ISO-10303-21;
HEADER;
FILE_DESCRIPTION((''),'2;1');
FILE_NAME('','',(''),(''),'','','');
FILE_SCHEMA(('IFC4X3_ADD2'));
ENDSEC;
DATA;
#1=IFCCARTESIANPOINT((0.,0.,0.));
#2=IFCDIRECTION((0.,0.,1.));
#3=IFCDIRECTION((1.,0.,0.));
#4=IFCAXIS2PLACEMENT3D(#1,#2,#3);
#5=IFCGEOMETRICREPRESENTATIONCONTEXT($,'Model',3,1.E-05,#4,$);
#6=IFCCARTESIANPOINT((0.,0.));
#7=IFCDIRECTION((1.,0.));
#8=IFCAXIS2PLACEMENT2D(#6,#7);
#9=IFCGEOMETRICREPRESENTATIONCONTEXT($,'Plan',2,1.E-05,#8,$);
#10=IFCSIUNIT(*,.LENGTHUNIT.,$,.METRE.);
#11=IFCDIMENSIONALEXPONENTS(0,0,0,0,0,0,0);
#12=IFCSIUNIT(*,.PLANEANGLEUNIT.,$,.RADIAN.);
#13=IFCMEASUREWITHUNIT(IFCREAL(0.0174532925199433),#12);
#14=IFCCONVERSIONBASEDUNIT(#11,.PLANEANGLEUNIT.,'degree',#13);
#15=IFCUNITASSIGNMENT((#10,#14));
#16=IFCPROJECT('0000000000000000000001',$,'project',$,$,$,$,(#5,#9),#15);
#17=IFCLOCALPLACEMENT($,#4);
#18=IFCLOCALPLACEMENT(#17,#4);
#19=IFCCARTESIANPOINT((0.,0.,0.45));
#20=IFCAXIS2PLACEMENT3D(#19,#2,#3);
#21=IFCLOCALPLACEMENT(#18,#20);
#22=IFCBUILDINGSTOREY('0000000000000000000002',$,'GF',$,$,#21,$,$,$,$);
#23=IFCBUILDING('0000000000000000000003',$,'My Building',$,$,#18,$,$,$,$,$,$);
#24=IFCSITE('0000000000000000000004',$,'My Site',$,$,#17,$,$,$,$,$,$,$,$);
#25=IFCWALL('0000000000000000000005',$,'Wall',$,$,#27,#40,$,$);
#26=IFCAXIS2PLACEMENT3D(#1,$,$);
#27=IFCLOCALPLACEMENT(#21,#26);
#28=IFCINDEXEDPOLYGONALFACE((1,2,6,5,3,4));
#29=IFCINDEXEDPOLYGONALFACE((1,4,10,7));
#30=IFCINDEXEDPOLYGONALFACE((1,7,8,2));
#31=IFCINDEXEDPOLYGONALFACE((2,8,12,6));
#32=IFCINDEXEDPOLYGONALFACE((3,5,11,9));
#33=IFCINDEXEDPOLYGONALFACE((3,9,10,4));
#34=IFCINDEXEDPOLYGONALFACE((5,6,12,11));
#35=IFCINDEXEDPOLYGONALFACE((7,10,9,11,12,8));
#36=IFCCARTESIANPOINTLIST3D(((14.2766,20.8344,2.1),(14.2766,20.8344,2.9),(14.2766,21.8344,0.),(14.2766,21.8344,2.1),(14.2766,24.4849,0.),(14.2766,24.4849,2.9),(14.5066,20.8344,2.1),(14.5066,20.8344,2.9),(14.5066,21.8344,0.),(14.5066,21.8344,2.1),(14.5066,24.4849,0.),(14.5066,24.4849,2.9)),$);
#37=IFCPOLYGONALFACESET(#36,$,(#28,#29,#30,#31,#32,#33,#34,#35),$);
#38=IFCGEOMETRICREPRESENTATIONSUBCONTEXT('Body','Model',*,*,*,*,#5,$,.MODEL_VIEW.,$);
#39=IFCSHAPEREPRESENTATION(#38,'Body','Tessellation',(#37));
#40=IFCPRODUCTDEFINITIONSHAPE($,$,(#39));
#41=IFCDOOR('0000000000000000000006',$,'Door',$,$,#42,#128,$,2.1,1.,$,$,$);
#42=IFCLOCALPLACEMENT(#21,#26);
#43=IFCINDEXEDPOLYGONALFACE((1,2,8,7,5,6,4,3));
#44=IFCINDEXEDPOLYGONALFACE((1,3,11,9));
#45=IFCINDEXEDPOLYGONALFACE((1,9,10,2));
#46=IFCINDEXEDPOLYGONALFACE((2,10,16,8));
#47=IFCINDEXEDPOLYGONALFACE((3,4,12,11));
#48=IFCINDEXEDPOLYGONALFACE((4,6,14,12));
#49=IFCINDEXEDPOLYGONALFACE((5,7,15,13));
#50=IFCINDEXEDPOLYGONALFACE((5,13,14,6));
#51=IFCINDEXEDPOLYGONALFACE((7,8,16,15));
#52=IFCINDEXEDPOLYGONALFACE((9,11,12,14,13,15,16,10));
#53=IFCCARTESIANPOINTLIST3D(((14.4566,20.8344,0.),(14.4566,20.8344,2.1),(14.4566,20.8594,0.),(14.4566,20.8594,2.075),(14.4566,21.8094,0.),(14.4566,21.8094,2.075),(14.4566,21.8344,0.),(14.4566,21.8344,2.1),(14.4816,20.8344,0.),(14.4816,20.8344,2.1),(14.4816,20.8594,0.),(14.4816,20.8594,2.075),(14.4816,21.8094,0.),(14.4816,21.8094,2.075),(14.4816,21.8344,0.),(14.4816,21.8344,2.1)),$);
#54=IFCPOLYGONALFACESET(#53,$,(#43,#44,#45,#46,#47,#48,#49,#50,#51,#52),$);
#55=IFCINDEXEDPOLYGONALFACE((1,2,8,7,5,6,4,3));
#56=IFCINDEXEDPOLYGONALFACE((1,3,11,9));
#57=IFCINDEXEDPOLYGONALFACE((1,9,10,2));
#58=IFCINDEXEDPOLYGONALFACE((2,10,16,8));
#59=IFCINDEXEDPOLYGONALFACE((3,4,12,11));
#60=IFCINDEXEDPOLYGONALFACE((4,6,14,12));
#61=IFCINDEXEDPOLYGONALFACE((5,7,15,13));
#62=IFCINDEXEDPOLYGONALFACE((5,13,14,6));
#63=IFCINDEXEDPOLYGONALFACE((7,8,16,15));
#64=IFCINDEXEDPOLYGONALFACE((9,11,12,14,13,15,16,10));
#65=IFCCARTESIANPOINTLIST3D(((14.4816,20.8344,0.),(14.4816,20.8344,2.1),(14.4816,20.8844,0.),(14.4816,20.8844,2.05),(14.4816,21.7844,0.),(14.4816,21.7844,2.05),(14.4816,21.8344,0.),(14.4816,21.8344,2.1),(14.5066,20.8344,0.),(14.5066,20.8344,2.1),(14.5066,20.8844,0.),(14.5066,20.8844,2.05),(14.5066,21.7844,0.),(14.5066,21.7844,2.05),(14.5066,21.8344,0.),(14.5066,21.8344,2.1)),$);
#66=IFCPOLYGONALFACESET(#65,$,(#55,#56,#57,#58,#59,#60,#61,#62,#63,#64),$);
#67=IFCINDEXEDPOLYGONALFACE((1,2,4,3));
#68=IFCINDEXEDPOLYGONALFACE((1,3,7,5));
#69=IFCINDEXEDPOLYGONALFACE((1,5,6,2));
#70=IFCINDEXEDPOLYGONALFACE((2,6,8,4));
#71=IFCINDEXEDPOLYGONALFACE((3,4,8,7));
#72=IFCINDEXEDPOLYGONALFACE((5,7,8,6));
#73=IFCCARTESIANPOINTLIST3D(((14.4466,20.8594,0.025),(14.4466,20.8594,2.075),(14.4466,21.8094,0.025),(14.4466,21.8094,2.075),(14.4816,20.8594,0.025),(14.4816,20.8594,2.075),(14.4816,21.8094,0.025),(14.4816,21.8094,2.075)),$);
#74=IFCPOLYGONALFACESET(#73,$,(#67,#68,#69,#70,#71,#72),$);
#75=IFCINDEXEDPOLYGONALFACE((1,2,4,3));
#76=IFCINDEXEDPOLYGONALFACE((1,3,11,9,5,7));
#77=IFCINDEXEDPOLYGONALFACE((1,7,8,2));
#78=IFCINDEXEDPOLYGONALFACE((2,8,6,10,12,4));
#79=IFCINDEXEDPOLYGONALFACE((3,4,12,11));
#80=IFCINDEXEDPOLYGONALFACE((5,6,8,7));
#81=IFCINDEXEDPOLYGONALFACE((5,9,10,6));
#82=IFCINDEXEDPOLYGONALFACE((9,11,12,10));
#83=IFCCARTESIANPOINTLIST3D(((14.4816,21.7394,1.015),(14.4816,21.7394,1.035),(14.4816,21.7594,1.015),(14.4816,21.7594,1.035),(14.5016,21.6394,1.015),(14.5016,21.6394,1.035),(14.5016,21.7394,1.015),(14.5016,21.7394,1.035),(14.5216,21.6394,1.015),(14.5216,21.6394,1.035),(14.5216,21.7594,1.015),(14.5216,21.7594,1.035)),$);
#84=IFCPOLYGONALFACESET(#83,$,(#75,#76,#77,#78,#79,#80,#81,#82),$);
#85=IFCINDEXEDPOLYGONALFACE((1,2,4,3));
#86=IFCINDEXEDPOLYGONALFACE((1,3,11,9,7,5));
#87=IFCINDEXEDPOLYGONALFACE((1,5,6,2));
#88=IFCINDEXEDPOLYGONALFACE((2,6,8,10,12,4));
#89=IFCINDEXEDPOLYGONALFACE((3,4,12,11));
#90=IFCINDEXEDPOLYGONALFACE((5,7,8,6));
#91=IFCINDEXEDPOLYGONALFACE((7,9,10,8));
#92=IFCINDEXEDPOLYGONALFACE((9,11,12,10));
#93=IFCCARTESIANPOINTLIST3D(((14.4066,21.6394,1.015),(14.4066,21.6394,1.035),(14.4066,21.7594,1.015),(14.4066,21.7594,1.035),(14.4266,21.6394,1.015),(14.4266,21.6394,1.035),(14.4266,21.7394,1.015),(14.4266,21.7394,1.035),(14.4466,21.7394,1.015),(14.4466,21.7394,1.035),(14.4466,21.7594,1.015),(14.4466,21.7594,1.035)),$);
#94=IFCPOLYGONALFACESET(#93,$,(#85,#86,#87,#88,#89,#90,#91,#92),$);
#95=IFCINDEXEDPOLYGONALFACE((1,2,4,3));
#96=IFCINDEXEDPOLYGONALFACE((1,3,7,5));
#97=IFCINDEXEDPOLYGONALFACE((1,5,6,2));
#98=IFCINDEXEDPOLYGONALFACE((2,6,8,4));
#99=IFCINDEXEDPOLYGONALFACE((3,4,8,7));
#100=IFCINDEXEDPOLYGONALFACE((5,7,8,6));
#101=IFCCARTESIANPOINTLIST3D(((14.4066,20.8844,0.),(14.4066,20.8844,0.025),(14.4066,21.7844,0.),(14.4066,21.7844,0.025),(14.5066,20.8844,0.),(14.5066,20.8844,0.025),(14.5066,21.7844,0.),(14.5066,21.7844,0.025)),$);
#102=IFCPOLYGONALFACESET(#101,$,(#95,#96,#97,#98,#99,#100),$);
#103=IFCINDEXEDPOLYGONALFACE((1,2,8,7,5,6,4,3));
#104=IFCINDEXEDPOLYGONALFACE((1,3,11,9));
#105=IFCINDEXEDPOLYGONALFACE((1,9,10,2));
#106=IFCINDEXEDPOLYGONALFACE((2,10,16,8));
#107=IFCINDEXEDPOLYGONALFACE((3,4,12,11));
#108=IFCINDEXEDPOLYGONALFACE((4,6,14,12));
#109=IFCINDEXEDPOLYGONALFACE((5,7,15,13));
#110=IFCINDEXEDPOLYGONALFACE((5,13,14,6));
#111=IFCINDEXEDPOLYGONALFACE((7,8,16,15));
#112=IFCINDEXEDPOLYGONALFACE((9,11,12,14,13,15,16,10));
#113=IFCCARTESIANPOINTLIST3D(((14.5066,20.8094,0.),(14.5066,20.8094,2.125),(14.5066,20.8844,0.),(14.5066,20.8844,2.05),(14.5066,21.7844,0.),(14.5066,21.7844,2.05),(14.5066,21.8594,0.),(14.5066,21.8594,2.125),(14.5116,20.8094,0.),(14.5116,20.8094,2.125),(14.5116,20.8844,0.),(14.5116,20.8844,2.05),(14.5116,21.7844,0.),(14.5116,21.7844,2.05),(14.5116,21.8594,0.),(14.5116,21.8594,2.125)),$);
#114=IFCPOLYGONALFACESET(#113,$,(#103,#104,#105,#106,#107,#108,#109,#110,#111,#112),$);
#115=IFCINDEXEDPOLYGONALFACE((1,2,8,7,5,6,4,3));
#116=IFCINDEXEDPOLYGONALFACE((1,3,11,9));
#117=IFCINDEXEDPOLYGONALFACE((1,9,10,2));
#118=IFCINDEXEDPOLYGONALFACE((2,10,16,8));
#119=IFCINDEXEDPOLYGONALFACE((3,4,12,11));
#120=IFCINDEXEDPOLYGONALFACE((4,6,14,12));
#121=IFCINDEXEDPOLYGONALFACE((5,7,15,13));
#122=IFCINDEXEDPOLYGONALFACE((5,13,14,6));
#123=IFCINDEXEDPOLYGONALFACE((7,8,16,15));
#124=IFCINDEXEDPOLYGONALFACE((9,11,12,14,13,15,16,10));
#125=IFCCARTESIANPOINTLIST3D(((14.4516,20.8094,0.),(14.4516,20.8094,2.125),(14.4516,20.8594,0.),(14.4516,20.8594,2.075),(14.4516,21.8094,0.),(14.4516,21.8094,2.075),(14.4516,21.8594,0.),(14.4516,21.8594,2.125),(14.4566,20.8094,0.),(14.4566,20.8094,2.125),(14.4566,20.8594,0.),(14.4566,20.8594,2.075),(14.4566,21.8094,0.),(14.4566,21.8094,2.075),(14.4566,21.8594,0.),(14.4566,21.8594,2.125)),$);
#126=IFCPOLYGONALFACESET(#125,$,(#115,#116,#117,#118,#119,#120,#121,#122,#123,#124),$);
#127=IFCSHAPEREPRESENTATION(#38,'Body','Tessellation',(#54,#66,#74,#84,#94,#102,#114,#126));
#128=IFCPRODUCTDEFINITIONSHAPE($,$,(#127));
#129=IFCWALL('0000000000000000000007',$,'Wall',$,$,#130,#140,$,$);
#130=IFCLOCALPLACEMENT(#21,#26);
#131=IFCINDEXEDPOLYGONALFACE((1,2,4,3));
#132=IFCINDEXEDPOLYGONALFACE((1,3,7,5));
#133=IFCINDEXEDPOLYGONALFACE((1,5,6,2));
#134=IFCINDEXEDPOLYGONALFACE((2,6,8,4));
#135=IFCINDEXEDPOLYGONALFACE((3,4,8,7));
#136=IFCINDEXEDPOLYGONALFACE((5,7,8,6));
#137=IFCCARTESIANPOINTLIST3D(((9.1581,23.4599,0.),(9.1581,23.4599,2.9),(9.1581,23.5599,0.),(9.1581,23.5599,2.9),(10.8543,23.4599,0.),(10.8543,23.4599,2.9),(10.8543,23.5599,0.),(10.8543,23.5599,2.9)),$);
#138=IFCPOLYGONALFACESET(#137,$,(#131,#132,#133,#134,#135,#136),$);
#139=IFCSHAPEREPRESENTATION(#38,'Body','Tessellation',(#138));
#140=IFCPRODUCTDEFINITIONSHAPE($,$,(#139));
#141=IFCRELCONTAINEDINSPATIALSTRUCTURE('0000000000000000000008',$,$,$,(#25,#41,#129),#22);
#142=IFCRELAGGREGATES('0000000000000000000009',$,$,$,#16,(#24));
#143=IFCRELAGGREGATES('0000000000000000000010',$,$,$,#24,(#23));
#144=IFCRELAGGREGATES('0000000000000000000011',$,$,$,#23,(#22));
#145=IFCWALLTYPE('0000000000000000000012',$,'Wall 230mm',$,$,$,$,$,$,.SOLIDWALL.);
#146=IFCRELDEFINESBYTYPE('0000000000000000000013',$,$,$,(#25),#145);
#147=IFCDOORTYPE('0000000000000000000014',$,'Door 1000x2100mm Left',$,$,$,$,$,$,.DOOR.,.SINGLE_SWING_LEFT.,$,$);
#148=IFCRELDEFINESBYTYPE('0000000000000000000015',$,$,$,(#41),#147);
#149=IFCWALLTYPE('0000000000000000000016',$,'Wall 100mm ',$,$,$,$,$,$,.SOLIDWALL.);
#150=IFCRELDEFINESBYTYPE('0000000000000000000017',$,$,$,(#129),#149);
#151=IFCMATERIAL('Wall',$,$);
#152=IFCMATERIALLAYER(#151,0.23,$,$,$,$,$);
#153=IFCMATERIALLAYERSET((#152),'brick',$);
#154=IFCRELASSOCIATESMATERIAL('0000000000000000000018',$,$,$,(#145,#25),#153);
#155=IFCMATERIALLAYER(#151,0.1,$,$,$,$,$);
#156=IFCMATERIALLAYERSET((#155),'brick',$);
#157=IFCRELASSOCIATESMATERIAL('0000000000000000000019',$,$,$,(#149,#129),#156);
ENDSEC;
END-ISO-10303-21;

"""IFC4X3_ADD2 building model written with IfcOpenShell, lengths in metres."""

from ifc_helpers import new_model, entity, si_unit, converted_unit, frame, origin_with_axes, origin_2d_with_axis, place, context, subcontext, project, spatial, line, indexed_curve, outline, extrude, shape, source, transform, mapped, material, layer, layer_set, layer_usage, type_object, type_shapes, element, fill, save


model = new_model("IFC4X3_ADD2")

# Units and contexts
model_context = context("Model", 3, precision=1e-05, world=origin_with_axes())
plan_context = context("Plan", 2, precision=1e-05, world=origin_2d_with_axis())
body_context_1 = subcontext(model_context, "Body", "Model", "MODEL_VIEW")
body_context_2 = subcontext(plan_context, "Body", "Plan", "PLAN_VIEW")
ifc_project = project(units=[si_unit("LENGTHUNIT", "METRE"), converted_unit("PLANEANGLEUNIT", "degree", entity("IfcReal", 0.0174532925199433), si_unit("PLANEANGLEUNIT", "RADIAN"), dimensions=[0, 0, 0, 0, 0, 0, 0])], contexts=[model_context, plan_context])

# Site, building, storey
site_placement = place(None, origin_with_axes())
site = spatial("IfcSite", under=ifc_project, at=site_placement, Name="My Site")
building_placement = place(site_placement, origin_with_axes())
building = spatial("IfcBuilding", under=site, at=building_placement, Name="My Building")
storey_placement = place(building_placement, frame((0.0, 0.0, 0.45), z_axis=(0.0, 0.0, 1.0), x_axis=(1.0, 0.0, 0.0)))
storey = spatial("IfcBuildingStorey", under=building, at=storey_placement, Name="GF")

# Shared definitions
ifc_material_1 = material(Name="Wall")
ifc_layer_1 = layer(ifc_material_1, 0.23)
ifc_layer_set_1 = layer_set([ifc_layer_1], Name="brick")
wall_type_1 = type_object("IfcWallType", Name="Wall 230mm", PredefinedType="SOLIDWALL", material=ifc_layer_set_1)

# Wall, opening, door
ifc_layer_usage_1 = layer_usage(ifc_layer_set_1, "AXIS2", "POSITIVE", 0.0)
wall_1_placement = place(storey_placement, frame((14.5066, 20.8344, 0.0), z_axis=(0.0, 0.0, 1.0), x_axis=(0.0, 1.0, 0.0)))
wall_1 = element("IfcWall", 1, at=wall_1_placement, inside=storey, type_object=wall_type_1, material=ifc_layer_usage_1, Name="Wall", context=body_context_1, shape_type="SweptSolid", body=[
    extrude(outline(indexed_curve([(0.0, 0.0), (0.0, 0.23), (3.6505, 0.23), (3.6505, 0.0), (0.0, 0.0)], self_intersect=False)), origin_with_axes(), (0.0, 0.0, 1.0), 2.9),
])
shared_shape_1 = source(origin_with_axes(), body_context_1, "Body", "SweptSolid", [
    extrude(outline(indexed_curve([(0.0, 0.0), (1.0, 0.0), (1.0, 2.1), (0.0, 2.1)], segments=[line(1, 2, 3, 4, 1)])), frame((0.0, -0.6, 0.0), z_axis=(0.0, -1.0, 0.0), x_axis=(1.0, 0.0, 0.0)), (0.0, 0.0, -1.0), 1.2),
])
opening_1_placement = place(wall_1_placement, frame((0.0, 0.0, 0.0), z_axis=(0.0, 0.0, 1.0), x_axis=(1.0, 0.0, 0.0)))
opening_1 = element("IfcOpeningElement", 2, at=opening_1_placement, cuts=wall_1, PredefinedType="OPENING", context=body_context_1, shape_type="MappedRepresentation", body=[
    mapped(shared_shape_1, transform((0.0, 0.0, 0.0), x_axis=(1.0, 0.0, 0.0), y_axis=(0.0, 1.0, 0.0), z_axis=(0.0, 0.0, 1.0), scale=1.0)),
])
door_type_1 = type_object("IfcDoorType", Name="Door 1000x2100mm Left", OperationType="SINGLE_SWING_LEFT", PredefinedType="DOOR")
shared_shape_2 = source(origin_with_axes(), body_context_1, "Body", "SweptSolid", [
    extrude(outline(indexed_curve([(0.0, 0.0), (0.0, 2.1), (1.0, 2.1), (1.0, 0.0), (0.975, 0.0), (0.975, 2.075), (0.025, 2.075), (0.025, 0.0)], segments=[line(1, 2, 3, 4, 5, 6, 7, 8, 1)])), frame((0.0, 0.025, 0.0), z_axis=(0.0, -1.0, 0.0), x_axis=(1.0, 0.0, 0.0)), (0.0, 0.0, -1.0), 0.025),
    extrude(outline(indexed_curve([(0.0, 0.0), (0.0, 2.1), (1.0, 2.1), (1.0, 0.0), (0.95, 0.0), (0.95, 2.05), (0.05, 2.05), (0.05, 0.0)], segments=[line(1, 2, 3, 4, 5, 6, 7, 8, 1)])), frame((0.0, 0.0, 0.0), z_axis=(0.0, -1.0, 0.0), x_axis=(1.0, 0.0, 0.0)), (0.0, 0.0, -1.0), 0.025),
    extrude(outline(indexed_curve([(0.0, 0.0), (0.95, 0.0), (0.95, 0.035), (0.0, 0.035)], segments=[line(1, 2, 3, 4, 1)])), frame((0.025, 0.025, 0.025), z_axis=(0.0, 0.0, 1.0), x_axis=(1.0, 0.0, 0.0)), (0.0, 0.0, 1.0), 2.05),
    extrude(outline(indexed_curve([(0.0, 0.0), (0.0, -0.04), (-0.12, -0.04), (-0.12, -0.02), (-0.02, -0.02), (-0.02, 0.0)], segments=[line(1, 2, 3, 4, 5, 6, 1)])), frame((0.925, 0.025, 1.015), z_axis=(0.0, 0.0, 1.0), x_axis=(1.0, 0.0, 0.0)), (0.0, 0.0, 1.0), 0.02),
    extrude(outline(indexed_curve([(0.0, 0.0), (0.0, 0.04), (-0.12, 0.04), (-0.12, 0.02), (-0.02, 0.02), (-0.02, 0.0)], segments=[line(1, 2, 3, 4, 5, 6, 1)])), frame((0.925, 0.06, 1.015), z_axis=(0.0, 0.0, 1.0), x_axis=(1.0, 0.0, 0.0)), (0.0, 0.0, 1.0), 0.02),
    extrude(outline(indexed_curve([(0.0, 0.0), (0.9, 0.0), (0.9, 0.1), (0.0, 0.1)], segments=[line(1, 2, 3, 4, 1)])), frame((0.05, 0.0, 0.0), z_axis=(0.0, 0.0, 1.0), x_axis=(1.0, 0.0, 0.0)), (0.0, 0.0, 1.0), 0.025),
    extrude(outline(indexed_curve([(0.0, 0.0), (0.0, 2.125), (1.05, 2.125), (1.05, 0.0), (0.975, 0.0), (0.975, 2.05), (0.075, 2.05), (0.075, 0.0)], segments=[line(1, 2, 3, 4, 5, 6, 7, 8, 1)])), frame((-0.025, -0.005, 0.0), z_axis=(0.0, -1.0, 0.0), x_axis=(1.0, 0.0, 0.0)), (0.0, 0.0, -1.0), 0.005),
    extrude(outline(indexed_curve([(0.0, 0.0), (0.0, 2.125), (1.05, 2.125), (1.05, 0.0), (1.0, 0.0), (1.0, 2.075), (0.05, 2.075), (0.05, 0.0)], segments=[line(1, 2, 3, 4, 5, 6, 7, 8, 1)])), frame((-0.025, 0.05, 0.0), z_axis=(0.0, -1.0, 0.0), x_axis=(1.0, 0.0, 0.0)), (0.0, 0.0, -1.0), 0.005),
])
shared_shape_3 = source(origin_with_axes(), body_context_2, "Body", "Curve2D", [
    entity("IfcIndexedPolyCurve", entity("IfcCartesianPointList2D", [[0.0, 0.0], [0.0, 0.05], [0.025, 0.05], [0.025, 0.025], [0.05, 0.025], [0.05, 0.0]]), [entity("IfcLineIndex", [1, 2, 3, 4, 5, 6, 1])]),
    entity("IfcIndexedPolyCurve", entity("IfcCartesianPointList2D", [[1.0, 0.0], [1.0, 0.05], [0.975, 0.05], [0.975, 0.025], [0.95, 0.025], [0.95, 0.0]]), [entity("IfcLineIndex", [1, 2, 3, 4, 5, 6, 1])]),
    entity("IfcTrimmedCurve", entity("IfcEllipse", entity("IfcAxis2Placement2D", entity("IfcCartesianPoint", [0.06, 0.05]), entity("IfcDirection", [1.0, 0.0])), 0.915, 0.95), [entity("IfcCartesianPoint", [0.975, 0.05])], [entity("IfcCartesianPoint", [0.06, 1.0])], True, "CARTESIAN"),
    entity("IfcIndexedPolyCurve", entity("IfcCartesianPointList2D", [[0.025, 0.05], [0.06, 0.05], [0.06, 1.0], [0.025, 1.0]]), [entity("IfcLineIndex", [1, 2, 3, 4, 1])]),
])
type_shapes(door_type_1, [shared_shape_2, shared_shape_3])
door_1_placement = place(opening_1_placement, origin_with_axes())
door_1 = element("IfcDoor", 3, at=door_1_placement, inside=storey, type_object=door_type_1, Name="Door", OverallHeight=2.1, OverallWidth=1.0, shapes=[
    shape(body_context_1, "Body", "MappedRepresentation", [mapped(shared_shape_2, transform((0.0, 0.0, 0.0), x_axis=(1.0, 0.0, 0.0), y_axis=(0.0, 1.0, 0.0), z_axis=(0.0, 0.0, 1.0), scale=1.0))]),
    shape(body_context_2, "Body", "MappedRepresentation", [mapped(shared_shape_3, transform((0.0, 0.0, 0.0), x_axis=(1.0, 0.0, 0.0), y_axis=(0.0, 1.0, 0.0), z_axis=(0.0, 0.0, 1.0), scale=1.0))]),
])
fill(opening_1, door_1)

# Wall
ifc_layer_2 = layer(ifc_material_1, 0.1)
ifc_layer_set_2 = layer_set([ifc_layer_2], Name="brick")
ifc_layer_usage_2 = layer_usage(ifc_layer_set_2, "AXIS2", "POSITIVE", 0.0)
wall_type_2 = type_object("IfcWallType", Name="Wall 100mm ", PredefinedType="SOLIDWALL", material=ifc_layer_set_2)
wall_2_placement = place(storey_placement, frame((9.1581, 23.4599, 0.0), z_axis=(0.0, 0.0, 1.0), x_axis=(1.0, 0.0, 0.0)))
element("IfcWall", 4, at=wall_2_placement, inside=storey, type_object=wall_type_2, material=ifc_layer_usage_2, Name="Wall", context=body_context_1, shape_type="SweptSolid", body=[
    extrude(outline(indexed_curve([(0.0, 0.0), (0.0, 0.1), (1.6962, 0.1), (1.6962, 0.0), (0.0, 0.0)], self_intersect=False)), origin_with_axes(), (0.0, 0.0, 1.0), 2.9),
])

save(model, "model.ifc")
